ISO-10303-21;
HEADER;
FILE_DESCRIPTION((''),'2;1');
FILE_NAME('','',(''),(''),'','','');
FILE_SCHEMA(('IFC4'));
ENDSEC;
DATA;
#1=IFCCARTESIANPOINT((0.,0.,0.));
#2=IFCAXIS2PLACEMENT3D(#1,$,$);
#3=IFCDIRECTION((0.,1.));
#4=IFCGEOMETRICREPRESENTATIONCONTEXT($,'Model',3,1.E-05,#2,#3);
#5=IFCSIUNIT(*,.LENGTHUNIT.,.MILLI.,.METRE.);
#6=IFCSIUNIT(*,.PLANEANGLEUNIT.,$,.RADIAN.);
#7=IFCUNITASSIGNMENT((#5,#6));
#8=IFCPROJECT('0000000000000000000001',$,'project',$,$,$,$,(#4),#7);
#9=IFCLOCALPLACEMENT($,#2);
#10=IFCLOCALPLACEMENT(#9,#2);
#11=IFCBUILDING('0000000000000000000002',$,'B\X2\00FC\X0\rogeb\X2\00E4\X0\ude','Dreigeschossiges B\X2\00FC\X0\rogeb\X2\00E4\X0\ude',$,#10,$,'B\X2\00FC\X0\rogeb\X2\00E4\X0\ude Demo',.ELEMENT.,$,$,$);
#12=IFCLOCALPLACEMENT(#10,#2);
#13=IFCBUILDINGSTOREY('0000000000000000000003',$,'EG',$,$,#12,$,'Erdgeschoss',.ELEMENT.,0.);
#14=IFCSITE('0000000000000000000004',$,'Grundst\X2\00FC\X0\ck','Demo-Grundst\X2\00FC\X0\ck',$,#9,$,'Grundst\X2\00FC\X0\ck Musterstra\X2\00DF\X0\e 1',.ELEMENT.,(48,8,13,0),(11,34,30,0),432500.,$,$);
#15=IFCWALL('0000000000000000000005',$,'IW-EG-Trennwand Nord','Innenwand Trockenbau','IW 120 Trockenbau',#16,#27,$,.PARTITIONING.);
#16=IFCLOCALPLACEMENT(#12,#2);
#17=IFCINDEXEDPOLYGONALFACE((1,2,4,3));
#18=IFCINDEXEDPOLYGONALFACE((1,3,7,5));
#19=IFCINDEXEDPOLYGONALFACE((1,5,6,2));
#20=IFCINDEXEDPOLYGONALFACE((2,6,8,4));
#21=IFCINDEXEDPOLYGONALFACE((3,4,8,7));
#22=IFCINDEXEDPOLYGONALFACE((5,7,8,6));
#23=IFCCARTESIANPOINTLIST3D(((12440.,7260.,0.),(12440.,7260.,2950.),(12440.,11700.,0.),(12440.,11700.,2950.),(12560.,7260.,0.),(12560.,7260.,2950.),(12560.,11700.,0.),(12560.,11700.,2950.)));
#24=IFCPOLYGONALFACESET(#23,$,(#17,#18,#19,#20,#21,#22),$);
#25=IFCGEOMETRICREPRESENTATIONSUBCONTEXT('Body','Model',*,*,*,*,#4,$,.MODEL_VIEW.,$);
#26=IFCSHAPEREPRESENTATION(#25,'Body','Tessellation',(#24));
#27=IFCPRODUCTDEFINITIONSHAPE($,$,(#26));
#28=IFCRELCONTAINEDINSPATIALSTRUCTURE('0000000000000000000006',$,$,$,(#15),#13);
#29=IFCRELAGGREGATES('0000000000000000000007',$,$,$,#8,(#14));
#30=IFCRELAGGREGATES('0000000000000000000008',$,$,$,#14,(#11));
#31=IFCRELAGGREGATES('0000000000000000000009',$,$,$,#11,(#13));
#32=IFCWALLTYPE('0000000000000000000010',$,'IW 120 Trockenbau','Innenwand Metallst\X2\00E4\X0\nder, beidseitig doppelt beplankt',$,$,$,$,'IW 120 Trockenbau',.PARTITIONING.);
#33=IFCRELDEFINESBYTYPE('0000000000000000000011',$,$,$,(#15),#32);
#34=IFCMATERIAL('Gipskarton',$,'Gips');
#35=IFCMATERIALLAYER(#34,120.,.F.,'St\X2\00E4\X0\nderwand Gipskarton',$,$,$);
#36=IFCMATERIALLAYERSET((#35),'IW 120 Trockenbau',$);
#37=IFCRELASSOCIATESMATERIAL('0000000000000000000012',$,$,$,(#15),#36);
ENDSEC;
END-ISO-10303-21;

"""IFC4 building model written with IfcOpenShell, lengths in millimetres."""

from ifc_helpers import new_model, si_unit, direction, frame, frame_2d, origin, place, context, subcontext, project, spatial, rectangle, extrude, material, layer, layer_set, layer_usage, type_object, element, save


model = new_model("IFC4")

# Units and contexts
model_context = context("Model", 3, precision=1e-05, world=origin(), true_north=direction((0.0, 1.0)))
body_context = subcontext(model_context, "Body", "Model", "MODEL_VIEW")
ifc_project = project(units=[si_unit("LENGTHUNIT", "METRE", prefix="MILLI"), si_unit("PLANEANGLEUNIT", "RADIAN")], contexts=[model_context])

# Site, building, storey
site_placement = place(None, origin())
site = spatial("IfcSite", under=ifc_project, at=site_placement, Name="Grundstück", Description="Demo-Grundstück", LongName="Grundstück Musterstraße 1", CompositionType="ELEMENT", RefLatitude=(48, 8, 13, 0), RefLongitude=(11, 34, 30, 0), RefElevation=432500.0)
building_placement = place(site_placement, origin())
building = spatial("IfcBuilding", under=site, at=building_placement, Name="Bürogebäude", Description="Dreigeschossiges Bürogebäude", LongName="Bürogebäude Demo", CompositionType="ELEMENT")
storey_placement = place(building_placement, origin())
storey = spatial("IfcBuildingStorey", under=building, at=storey_placement, Name="EG", LongName="Erdgeschoss", CompositionType="ELEMENT", Elevation=0.0)

# Wall
ifc_material_1 = material(Name="Gipskarton", Category="Gips")
ifc_layer_1 = layer(ifc_material_1, 120.0, ventilated=False, Name="Ständerwand Gipskarton")
ifc_layer_set_1 = layer_set([ifc_layer_1], Name="IW 120 Trockenbau")
ifc_layer_usage_1 = layer_usage(ifc_layer_set_1, "AXIS2", "POSITIVE", -60.0)
wall_type_1 = type_object("IfcWallType", Name="IW 120 Trockenbau", Description="Innenwand Metallständer, beidseitig doppelt beplankt", ElementType="IW 120 Trockenbau", PredefinedType="PARTITIONING")
for number, where, z_axis, x_axis, name in (
    (1, (12500.0, 7260.0, 0.0), (0.0, 0.0, 1.0), (0.0, 1.0, 0.0), "IW-EG-Trennwand Nord"),
):
    element("IfcWall", number, at=place(storey_placement, frame(where, z_axis=z_axis, x_axis=x_axis)), inside=storey, type_object=wall_type_1, material=ifc_layer_usage_1, Name=name, Description="Innenwand Trockenbau", ObjectType="IW 120 Trockenbau", PredefinedType="PARTITIONING", context=body_context, shape_type="SweptSolid", body=[
        extrude(rectangle(XDim=4440.0, YDim=120.0, at=frame_2d((2220.0, 0.0))), origin(), (0.0, 0.0, 1.0), 2950.0),
    ])

save(model, "model.ifc")
